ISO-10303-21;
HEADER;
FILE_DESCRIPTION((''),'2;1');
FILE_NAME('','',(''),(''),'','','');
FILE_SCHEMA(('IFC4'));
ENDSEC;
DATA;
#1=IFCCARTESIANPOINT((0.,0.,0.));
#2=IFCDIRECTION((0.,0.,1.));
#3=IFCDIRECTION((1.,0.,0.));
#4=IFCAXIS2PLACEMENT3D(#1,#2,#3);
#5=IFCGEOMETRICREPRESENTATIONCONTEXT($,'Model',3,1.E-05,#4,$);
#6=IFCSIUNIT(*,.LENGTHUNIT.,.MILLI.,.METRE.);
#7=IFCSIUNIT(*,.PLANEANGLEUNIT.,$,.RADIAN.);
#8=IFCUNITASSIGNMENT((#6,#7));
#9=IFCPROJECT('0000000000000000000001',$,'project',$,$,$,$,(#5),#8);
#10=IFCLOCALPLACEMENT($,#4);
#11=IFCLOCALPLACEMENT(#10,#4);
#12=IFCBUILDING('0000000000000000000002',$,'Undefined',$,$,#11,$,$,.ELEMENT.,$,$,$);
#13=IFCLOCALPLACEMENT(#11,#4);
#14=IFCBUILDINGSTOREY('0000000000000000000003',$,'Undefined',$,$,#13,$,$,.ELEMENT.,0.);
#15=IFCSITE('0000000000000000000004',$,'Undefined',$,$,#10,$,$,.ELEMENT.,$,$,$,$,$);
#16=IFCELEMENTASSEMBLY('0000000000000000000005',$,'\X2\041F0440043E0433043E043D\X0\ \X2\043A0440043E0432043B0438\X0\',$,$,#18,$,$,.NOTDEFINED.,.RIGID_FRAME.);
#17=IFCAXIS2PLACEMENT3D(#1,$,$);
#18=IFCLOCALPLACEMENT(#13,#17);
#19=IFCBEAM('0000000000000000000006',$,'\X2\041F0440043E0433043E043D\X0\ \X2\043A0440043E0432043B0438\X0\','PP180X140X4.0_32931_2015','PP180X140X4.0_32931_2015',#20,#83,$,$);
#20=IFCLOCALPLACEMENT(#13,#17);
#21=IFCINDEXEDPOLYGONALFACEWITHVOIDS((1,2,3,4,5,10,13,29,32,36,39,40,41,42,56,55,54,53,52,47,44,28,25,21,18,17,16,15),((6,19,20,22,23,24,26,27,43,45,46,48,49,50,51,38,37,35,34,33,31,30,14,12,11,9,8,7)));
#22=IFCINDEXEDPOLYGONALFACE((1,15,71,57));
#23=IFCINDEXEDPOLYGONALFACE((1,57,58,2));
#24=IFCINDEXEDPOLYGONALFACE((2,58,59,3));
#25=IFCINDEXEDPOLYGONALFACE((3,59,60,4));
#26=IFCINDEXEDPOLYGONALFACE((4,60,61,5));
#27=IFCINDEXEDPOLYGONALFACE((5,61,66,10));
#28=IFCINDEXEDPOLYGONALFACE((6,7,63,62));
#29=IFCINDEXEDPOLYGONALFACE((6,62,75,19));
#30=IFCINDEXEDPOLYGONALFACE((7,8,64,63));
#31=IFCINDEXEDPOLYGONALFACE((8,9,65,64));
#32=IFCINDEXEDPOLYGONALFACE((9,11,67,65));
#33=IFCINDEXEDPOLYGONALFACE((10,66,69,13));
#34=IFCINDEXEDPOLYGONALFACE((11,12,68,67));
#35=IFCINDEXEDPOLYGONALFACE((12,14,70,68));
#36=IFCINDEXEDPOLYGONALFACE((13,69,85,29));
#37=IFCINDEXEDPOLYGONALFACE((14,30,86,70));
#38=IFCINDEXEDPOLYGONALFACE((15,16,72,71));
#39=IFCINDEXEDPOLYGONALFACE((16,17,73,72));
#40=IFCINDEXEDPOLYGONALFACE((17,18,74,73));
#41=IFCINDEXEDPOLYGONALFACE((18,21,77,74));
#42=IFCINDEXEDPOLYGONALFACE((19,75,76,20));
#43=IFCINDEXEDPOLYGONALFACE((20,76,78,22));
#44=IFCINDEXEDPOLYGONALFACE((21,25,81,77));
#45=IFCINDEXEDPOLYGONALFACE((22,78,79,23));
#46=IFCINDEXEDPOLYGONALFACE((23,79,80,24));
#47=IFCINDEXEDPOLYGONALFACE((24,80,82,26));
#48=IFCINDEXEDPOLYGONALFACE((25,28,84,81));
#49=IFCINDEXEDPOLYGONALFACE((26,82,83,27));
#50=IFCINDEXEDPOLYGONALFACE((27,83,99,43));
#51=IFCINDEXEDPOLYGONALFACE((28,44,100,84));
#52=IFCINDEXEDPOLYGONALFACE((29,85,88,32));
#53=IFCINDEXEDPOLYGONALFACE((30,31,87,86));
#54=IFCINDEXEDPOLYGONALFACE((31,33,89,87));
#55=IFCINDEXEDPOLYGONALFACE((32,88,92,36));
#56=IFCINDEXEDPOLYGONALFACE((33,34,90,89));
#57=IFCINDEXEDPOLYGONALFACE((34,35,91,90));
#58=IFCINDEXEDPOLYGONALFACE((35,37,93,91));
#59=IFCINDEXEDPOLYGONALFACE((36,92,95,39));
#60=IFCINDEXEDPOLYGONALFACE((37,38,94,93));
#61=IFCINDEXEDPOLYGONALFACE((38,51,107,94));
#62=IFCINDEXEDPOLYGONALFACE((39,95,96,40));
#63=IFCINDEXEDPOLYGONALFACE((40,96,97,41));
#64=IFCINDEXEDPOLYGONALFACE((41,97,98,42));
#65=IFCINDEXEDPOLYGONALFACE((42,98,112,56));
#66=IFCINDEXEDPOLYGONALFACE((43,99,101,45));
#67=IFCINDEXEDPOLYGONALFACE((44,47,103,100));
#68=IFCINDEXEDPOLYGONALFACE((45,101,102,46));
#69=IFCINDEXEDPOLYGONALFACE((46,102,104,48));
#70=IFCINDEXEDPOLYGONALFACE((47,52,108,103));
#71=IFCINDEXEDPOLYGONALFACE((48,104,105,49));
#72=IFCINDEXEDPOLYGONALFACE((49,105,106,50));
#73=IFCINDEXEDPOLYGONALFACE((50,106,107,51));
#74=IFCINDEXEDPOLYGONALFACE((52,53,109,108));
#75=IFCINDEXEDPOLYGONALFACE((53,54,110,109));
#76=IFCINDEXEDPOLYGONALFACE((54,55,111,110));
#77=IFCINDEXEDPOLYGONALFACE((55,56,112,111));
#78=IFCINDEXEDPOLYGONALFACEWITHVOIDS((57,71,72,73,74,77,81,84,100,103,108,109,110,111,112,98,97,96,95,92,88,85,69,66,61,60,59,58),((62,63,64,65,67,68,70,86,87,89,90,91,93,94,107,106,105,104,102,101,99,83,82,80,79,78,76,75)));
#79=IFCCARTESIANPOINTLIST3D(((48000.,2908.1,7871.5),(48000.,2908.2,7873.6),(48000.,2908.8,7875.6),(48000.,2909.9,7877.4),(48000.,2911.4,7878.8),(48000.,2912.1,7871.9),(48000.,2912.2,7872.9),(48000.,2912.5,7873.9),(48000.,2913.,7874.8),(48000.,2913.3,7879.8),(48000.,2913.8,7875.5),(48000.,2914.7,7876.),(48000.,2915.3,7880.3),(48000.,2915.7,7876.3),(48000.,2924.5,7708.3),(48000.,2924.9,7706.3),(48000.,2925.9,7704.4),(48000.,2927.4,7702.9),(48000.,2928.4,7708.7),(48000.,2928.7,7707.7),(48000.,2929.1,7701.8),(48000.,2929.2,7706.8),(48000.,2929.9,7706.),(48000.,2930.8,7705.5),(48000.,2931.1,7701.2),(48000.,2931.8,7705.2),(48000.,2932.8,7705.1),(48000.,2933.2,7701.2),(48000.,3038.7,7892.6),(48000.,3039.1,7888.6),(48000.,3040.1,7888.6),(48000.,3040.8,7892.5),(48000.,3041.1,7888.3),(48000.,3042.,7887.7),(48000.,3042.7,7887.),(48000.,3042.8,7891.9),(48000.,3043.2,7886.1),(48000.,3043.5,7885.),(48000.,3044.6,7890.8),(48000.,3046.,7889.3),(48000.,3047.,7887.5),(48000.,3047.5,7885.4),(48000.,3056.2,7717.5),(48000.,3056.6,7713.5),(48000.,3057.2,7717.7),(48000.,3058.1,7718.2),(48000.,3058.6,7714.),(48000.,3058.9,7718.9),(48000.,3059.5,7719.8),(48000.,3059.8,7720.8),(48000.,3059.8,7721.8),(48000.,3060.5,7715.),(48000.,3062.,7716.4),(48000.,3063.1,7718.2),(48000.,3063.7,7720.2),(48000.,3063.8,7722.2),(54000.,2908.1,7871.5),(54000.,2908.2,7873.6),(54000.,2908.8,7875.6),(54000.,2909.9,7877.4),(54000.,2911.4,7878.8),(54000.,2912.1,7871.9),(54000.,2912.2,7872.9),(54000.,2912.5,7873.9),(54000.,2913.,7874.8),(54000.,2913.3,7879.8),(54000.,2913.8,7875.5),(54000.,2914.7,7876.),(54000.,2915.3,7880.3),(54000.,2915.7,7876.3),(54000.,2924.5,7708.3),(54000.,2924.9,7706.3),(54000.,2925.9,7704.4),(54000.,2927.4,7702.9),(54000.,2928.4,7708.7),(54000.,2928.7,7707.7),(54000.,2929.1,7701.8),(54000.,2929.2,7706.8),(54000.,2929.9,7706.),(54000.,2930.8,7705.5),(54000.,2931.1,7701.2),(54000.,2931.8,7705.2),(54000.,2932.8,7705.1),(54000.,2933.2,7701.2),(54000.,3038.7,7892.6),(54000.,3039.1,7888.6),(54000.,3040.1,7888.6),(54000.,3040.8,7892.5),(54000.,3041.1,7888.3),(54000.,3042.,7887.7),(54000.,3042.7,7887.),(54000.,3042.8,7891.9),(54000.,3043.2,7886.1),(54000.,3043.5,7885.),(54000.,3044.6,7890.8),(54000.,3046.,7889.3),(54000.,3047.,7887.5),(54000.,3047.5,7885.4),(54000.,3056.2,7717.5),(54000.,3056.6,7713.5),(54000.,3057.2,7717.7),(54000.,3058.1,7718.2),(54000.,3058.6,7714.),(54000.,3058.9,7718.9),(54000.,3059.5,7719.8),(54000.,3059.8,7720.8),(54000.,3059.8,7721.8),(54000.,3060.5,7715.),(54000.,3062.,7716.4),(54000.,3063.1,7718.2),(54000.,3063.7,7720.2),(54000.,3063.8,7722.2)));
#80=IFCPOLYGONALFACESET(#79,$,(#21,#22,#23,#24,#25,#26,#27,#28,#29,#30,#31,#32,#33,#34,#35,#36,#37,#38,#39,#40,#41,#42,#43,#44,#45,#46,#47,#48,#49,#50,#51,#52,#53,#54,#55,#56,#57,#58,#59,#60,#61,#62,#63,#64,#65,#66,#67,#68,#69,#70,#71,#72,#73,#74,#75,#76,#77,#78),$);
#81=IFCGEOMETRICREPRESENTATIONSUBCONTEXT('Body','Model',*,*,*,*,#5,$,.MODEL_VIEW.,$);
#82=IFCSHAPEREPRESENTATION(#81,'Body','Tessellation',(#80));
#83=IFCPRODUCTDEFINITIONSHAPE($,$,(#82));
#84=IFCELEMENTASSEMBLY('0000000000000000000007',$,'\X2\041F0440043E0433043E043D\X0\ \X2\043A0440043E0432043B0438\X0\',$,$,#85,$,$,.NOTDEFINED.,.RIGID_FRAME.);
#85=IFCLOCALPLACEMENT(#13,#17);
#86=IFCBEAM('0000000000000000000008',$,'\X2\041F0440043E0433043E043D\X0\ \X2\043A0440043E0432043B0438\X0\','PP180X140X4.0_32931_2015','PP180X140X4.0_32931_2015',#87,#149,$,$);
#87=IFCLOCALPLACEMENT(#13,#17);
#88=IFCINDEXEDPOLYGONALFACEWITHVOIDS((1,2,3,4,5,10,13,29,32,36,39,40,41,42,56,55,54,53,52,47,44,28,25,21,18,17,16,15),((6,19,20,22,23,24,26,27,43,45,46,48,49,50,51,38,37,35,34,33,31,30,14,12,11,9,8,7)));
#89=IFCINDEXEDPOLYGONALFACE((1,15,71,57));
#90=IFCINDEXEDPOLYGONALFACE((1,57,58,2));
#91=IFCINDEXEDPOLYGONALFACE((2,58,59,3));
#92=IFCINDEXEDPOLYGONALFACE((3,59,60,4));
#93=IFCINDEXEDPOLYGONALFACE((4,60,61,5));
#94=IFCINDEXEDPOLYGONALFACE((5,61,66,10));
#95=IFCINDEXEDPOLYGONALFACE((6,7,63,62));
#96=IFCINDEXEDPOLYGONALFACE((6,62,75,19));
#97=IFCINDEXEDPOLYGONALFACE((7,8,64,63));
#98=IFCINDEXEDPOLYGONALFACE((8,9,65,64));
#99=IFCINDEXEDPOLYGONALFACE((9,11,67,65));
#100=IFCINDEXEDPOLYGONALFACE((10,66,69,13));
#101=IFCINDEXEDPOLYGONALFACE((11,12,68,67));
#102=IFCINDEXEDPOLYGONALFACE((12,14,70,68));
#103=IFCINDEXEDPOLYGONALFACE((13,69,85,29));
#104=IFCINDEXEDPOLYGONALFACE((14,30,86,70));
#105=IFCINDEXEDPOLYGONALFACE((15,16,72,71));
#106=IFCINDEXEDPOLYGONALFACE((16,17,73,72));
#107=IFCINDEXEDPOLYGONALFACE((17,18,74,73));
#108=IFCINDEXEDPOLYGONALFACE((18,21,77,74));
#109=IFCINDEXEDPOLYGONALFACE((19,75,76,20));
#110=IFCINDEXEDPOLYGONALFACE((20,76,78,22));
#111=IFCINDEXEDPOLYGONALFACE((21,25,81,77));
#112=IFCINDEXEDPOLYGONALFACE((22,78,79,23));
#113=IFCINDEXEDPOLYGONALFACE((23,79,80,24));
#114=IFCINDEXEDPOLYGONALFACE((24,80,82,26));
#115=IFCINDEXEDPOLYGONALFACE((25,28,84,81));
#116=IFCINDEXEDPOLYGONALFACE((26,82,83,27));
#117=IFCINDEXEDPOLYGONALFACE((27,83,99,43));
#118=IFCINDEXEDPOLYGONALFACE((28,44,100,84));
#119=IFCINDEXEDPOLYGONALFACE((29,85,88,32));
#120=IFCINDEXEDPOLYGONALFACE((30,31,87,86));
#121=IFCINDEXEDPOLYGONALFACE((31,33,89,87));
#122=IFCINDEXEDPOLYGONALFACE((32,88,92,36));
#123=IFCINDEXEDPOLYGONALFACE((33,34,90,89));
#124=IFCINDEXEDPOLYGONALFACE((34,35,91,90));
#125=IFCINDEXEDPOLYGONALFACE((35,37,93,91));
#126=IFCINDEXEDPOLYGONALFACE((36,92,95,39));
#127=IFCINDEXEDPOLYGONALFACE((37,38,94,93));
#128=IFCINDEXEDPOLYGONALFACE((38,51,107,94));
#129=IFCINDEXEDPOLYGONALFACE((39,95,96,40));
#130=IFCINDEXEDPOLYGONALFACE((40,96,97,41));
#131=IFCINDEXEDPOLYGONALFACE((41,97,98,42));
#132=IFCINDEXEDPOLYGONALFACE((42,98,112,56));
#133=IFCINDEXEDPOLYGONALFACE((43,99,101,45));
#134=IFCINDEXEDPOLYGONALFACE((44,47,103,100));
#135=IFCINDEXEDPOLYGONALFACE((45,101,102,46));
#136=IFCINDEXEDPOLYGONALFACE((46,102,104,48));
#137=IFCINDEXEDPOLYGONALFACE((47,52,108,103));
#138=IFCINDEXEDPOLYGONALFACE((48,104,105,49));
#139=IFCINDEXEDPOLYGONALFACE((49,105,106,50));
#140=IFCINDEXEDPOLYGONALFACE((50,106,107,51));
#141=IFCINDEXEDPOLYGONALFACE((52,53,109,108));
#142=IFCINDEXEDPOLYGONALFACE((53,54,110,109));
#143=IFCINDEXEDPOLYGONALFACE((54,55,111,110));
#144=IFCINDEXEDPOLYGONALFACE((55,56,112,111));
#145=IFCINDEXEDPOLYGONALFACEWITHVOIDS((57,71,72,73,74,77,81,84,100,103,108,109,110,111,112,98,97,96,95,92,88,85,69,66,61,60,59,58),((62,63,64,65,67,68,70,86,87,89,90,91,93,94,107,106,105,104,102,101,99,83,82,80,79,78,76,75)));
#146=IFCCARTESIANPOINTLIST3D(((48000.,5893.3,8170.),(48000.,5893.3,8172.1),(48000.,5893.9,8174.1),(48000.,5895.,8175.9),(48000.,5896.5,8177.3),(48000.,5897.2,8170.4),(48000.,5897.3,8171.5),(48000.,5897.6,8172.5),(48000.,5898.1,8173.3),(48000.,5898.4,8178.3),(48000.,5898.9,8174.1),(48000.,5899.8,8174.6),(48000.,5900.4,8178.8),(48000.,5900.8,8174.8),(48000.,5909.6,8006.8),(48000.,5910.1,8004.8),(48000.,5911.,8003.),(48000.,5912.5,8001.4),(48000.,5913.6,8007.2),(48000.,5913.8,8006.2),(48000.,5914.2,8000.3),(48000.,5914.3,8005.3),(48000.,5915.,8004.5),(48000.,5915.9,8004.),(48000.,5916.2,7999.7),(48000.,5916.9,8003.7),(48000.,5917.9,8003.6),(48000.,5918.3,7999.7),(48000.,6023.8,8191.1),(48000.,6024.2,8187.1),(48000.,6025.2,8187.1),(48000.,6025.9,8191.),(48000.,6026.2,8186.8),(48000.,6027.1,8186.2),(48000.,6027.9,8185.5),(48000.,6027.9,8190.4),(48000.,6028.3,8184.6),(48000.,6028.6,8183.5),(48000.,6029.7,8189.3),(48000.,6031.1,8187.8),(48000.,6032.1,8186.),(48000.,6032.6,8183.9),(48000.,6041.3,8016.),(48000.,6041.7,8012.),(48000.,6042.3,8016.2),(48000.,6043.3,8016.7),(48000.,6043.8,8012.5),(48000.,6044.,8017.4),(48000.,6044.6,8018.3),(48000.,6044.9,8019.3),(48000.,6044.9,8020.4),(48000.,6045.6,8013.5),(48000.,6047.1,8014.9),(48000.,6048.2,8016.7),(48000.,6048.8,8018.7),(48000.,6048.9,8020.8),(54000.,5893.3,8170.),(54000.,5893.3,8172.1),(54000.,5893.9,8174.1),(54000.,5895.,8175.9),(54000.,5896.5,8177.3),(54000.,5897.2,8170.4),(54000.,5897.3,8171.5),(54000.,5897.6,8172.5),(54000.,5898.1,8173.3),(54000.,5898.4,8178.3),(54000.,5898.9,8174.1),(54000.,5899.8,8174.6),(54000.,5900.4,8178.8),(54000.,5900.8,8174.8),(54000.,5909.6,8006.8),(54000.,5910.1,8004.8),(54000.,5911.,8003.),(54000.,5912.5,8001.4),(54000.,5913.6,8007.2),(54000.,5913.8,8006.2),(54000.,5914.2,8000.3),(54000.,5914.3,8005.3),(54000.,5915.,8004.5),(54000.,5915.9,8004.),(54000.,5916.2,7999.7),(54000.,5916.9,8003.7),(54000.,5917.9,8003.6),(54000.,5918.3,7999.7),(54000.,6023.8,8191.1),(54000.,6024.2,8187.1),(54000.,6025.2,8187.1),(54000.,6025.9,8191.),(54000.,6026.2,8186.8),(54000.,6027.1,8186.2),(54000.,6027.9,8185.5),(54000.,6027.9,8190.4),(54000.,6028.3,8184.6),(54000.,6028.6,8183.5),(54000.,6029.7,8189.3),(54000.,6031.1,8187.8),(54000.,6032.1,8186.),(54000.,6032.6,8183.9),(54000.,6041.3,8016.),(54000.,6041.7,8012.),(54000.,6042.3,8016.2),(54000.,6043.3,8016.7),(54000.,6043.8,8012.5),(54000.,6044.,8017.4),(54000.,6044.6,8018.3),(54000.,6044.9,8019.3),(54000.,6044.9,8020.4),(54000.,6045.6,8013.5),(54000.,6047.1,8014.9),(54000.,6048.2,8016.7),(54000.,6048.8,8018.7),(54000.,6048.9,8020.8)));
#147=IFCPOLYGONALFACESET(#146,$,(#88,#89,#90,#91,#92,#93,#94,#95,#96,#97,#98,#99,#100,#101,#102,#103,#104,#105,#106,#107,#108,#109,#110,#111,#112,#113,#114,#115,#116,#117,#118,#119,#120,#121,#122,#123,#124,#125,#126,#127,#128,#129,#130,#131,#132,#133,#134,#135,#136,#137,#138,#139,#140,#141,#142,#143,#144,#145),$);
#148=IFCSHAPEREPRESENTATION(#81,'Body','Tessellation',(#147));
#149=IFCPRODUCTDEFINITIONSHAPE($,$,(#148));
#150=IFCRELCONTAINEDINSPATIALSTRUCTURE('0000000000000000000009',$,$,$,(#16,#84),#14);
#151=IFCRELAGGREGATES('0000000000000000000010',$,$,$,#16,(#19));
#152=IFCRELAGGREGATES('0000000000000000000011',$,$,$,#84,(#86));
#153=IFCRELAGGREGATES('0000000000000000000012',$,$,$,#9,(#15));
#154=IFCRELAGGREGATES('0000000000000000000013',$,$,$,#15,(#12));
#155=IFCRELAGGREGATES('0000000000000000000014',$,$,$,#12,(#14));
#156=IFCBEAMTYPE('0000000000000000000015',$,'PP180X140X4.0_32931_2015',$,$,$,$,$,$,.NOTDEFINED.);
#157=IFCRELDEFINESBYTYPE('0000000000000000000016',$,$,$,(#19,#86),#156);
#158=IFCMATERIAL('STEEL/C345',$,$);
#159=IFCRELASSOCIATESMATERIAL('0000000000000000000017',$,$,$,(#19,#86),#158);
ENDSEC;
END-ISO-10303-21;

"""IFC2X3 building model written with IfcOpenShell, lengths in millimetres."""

from ifc_helpers import new_model, si_unit, frame, origin_with_axes, origin_2d_with_axis, place, context, subcontext, project, spatial, hollow_rectangle, extrude, material, type_object, element, aggregate, save


model = new_model("IFC2X3")

# Units and contexts
model_context = context("Model", 3, precision=1e-05, world=origin_with_axes())
body_context = subcontext(model_context, "Body", "Model", "MODEL_VIEW")
ifc_project = project(units=[si_unit("LENGTHUNIT", "METRE", prefix="MILLI"), si_unit("PLANEANGLEUNIT", "RADIAN")], contexts=[model_context])

# Site, building, storey
site_placement = place(None, origin_with_axes())
site = spatial("IfcSite", under=ifc_project, at=site_placement, Name="Undefined", CompositionType="ELEMENT")
building_placement = place(site_placement, origin_with_axes())
building = spatial("IfcBuilding", under=site, at=building_placement, Name="Undefined", CompositionType="ELEMENT")
storey_placement = place(building_placement, origin_with_axes())
storey = spatial("IfcBuildingStorey", under=building, at=storey_placement, Name="Undefined", CompositionType="ELEMENT", Elevation=0.0)

# Element assemblies, beams
assembly_1_placement = place(storey_placement, origin_with_axes())
assembly_1 = element("IfcElementAssembly", 1, at=assembly_1_placement, inside=storey, Name="Прогон кровли", AssemblyPlace="NOTDEFINED", PredefinedType="RIGID_FRAME")
ifc_material_1 = material(Name="STEEL/C345")
beam_type_1 = type_object("IfcBeamType", Name="PP180X140X4.0_32931_2015", PredefinedType="NOTDEFINED")
beam_1_placement = place(assembly_1_placement, frame((48000.0, 2986.0, 7796.9), z_axis=(0.0, -0.099504, 0.995037), x_axis=(1.0, 0.0, 0.0)))
beam_1 = element("IfcBeam", 2, at=beam_1_placement, type_object=beam_type_1, material=ifc_material_1, Name="Прогон кровли", Description="PP180X140X4.0_32931_2015", ObjectType="PP180X140X4.0_32931_2015", context=body_context, shape_type="SweptSolid", body=[
    extrude(hollow_rectangle(XDim=140.0, YDim=180.0, WallThickness=4.0, InnerFilletRadius=4.0, OuterFilletRadius=8.0, at=origin_2d_with_axis()), frame((6000.0, 0.0, 0.0), z_axis=(-1.0, 0.0, 0.0), x_axis=(0.0, -1.0, 0.0)), (0.0, 0.0, 1.0), 6000.0),
])
aggregate(assembly_1, [beam_1])
assembly_2_placement = place(storey_placement, origin_with_axes())
assembly_2 = element("IfcElementAssembly", 3, at=assembly_2_placement, inside=storey, Name="Прогон кровли", AssemblyPlace="NOTDEFINED", PredefinedType="RIGID_FRAME")
beam_2_placement = place(assembly_2_placement, frame((48000.0, 5971.1, 8095.4), z_axis=(0.0, -0.099504, 0.995037), x_axis=(1.0, 0.0, 0.0)))
beam_2 = element("IfcBeam", 4, at=beam_2_placement, type_object=beam_type_1, material=ifc_material_1, Name="Прогон кровли", Description="PP180X140X4.0_32931_2015", ObjectType="PP180X140X4.0_32931_2015", context=body_context, shape_type="SweptSolid", body=[
    extrude(hollow_rectangle(XDim=140.0, YDim=180.0, WallThickness=4.0, InnerFilletRadius=4.0, OuterFilletRadius=8.0, at=origin_2d_with_axis()), frame((6000.0, 0.0, 0.0), z_axis=(-1.0, 0.0, 0.0), x_axis=(0.0, -1.0, 0.0)), (0.0, 0.0, 1.0), 6000.0),
])
aggregate(assembly_2, [beam_2])

save(model, "model.ifc")
